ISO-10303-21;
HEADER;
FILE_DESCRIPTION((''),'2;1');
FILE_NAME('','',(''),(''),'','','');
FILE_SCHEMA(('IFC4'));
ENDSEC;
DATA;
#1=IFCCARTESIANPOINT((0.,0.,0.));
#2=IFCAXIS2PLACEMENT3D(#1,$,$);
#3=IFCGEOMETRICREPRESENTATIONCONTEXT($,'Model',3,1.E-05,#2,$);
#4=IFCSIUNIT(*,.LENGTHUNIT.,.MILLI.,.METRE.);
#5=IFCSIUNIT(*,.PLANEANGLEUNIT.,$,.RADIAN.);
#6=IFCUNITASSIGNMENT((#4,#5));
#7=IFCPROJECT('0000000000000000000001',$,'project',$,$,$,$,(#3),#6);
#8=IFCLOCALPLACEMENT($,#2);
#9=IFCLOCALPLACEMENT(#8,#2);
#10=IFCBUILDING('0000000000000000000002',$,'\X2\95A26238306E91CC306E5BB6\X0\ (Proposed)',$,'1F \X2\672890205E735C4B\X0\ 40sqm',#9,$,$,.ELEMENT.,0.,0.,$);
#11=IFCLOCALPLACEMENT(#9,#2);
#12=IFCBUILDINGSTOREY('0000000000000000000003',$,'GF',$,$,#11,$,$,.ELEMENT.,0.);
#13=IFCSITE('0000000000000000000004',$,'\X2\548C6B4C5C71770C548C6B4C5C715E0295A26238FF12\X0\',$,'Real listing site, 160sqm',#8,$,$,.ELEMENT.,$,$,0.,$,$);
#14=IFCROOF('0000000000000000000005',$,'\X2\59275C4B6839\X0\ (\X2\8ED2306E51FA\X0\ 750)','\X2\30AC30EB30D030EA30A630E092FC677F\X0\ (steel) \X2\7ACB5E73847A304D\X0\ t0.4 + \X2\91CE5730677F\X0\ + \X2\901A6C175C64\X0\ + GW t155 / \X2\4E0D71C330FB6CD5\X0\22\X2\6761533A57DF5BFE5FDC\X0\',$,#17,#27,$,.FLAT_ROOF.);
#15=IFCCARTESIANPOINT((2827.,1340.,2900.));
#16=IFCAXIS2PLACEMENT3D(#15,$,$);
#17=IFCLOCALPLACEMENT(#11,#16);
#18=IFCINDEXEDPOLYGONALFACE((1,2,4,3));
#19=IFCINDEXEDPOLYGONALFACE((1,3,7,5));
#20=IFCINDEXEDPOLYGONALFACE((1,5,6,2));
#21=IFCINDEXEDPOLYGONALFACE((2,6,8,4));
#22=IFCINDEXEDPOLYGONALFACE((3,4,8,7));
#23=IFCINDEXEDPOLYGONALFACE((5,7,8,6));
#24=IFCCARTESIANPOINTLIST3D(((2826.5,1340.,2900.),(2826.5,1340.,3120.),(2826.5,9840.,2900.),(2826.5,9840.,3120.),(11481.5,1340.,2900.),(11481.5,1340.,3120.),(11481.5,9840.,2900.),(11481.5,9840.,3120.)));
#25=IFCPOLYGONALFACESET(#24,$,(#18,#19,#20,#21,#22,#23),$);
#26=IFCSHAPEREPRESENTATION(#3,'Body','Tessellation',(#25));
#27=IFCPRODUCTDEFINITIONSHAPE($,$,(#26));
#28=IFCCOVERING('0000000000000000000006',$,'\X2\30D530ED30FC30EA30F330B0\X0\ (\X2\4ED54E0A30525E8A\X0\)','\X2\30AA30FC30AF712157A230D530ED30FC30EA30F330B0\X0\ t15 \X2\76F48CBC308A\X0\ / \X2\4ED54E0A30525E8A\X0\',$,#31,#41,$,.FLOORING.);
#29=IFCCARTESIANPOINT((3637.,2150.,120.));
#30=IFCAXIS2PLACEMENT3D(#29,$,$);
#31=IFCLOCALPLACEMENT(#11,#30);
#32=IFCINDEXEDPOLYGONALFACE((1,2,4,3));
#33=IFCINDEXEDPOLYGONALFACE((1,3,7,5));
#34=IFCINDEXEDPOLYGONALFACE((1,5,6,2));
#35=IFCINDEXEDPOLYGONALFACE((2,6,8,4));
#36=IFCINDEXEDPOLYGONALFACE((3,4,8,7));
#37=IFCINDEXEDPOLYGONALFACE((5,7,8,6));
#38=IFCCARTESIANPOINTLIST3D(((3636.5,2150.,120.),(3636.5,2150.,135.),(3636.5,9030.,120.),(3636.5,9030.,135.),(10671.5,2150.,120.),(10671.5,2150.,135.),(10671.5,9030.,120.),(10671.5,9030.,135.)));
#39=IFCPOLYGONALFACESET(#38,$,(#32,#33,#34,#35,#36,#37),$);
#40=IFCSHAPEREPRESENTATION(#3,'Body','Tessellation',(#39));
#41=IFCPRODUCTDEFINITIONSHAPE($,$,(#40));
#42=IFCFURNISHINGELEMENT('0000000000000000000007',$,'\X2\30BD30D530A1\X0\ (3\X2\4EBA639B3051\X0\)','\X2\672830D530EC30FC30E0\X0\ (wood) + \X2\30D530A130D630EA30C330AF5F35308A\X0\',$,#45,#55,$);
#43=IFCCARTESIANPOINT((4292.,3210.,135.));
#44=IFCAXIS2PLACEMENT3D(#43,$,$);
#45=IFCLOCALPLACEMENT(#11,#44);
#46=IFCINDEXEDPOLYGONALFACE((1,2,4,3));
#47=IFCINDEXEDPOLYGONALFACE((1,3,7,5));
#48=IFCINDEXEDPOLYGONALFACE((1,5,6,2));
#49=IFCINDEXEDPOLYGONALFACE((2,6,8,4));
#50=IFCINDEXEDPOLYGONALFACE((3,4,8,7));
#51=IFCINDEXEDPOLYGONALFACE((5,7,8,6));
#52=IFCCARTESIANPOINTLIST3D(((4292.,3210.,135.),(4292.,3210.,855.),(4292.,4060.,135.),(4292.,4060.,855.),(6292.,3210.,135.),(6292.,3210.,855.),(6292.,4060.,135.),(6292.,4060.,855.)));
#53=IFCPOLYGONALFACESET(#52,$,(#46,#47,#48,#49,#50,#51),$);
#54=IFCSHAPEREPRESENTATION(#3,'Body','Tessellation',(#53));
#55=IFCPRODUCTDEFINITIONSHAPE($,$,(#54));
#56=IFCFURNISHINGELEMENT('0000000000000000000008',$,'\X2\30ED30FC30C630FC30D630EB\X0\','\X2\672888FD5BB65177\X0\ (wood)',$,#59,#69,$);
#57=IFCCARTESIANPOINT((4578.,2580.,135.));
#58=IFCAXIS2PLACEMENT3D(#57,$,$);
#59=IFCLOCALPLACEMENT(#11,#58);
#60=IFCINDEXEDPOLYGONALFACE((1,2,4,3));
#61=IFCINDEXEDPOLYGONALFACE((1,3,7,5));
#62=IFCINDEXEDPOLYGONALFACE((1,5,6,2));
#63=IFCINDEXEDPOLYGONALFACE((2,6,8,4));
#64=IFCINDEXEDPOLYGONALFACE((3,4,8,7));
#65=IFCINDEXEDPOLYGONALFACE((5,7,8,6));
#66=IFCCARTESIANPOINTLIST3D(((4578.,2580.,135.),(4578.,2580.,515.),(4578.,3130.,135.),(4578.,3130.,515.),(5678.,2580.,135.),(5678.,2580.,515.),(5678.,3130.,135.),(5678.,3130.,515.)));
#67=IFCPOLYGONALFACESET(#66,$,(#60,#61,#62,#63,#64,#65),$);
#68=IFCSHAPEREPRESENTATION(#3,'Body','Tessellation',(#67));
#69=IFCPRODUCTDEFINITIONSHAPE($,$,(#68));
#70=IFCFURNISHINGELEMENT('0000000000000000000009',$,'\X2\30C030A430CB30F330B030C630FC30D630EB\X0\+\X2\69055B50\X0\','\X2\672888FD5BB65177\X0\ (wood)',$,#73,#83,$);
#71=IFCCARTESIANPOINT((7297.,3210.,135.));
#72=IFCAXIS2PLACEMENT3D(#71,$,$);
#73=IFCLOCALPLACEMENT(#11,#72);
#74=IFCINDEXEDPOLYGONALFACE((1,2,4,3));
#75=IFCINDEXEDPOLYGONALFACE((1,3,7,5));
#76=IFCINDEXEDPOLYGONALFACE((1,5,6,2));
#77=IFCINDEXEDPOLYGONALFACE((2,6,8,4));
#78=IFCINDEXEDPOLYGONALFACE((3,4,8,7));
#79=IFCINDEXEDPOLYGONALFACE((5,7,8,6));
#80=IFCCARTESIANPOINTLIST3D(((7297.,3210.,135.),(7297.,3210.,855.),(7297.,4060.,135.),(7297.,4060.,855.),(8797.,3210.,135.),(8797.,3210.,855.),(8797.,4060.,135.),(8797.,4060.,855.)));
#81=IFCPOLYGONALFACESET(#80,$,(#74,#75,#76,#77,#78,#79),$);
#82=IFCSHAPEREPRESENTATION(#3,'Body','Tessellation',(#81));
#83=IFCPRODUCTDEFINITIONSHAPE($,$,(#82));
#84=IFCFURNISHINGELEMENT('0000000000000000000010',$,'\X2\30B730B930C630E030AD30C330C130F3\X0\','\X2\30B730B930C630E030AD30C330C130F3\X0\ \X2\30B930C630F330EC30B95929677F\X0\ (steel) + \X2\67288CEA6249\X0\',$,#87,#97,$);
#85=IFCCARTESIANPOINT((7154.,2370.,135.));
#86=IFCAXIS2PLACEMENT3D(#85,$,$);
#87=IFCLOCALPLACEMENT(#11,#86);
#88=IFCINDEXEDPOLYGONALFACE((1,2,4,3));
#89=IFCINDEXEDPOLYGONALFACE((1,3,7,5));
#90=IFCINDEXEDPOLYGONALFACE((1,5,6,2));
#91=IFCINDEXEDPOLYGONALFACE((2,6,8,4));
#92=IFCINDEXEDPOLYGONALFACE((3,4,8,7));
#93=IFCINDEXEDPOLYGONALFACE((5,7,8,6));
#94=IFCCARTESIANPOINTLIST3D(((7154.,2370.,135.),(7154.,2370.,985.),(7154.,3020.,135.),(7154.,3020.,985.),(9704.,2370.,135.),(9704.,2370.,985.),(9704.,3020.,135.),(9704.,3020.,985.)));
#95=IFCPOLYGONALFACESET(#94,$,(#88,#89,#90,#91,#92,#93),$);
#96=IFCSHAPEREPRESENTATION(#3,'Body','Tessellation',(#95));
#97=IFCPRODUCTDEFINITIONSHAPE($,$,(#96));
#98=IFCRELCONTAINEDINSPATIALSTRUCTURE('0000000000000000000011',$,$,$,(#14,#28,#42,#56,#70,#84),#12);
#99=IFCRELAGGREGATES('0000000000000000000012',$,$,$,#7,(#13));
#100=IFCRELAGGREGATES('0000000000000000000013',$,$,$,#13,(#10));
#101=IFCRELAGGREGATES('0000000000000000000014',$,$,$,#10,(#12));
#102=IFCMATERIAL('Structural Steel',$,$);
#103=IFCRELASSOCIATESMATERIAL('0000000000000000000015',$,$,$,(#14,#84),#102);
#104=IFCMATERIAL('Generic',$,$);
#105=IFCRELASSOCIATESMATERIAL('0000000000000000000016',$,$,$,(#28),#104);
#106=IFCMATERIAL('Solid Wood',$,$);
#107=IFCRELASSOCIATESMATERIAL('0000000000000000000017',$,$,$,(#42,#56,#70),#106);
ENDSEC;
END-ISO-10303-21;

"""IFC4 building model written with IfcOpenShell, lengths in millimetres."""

from ifc_helpers import new_model, si_unit, frame, frame_2d, origin, place, context, project, spatial, rectangle, extrude, material, element, save


model = new_model("IFC4")

# Units and contexts
model_context = context("Model", 3, precision=1e-05, world=origin())
ifc_project = project(units=[si_unit("LENGTHUNIT", "METRE", prefix="MILLI"), si_unit("PLANEANGLEUNIT", "RADIAN")], contexts=[model_context])

# Site, building, storey
site_placement = place(None, origin())
site = spatial("IfcSite", under=ifc_project, at=site_placement, Name="和歌山県和歌山市関戸２", ObjectType="Real listing site, 160sqm", CompositionType="ELEMENT", RefElevation=0.0)
building_placement = place(site_placement, origin())
building = spatial("IfcBuilding", under=site, at=building_placement, Name="関戸の里の家 (Proposed)", ObjectType="1F 木造平屋 40sqm", CompositionType="ELEMENT", ElevationOfRefHeight=0.0, ElevationOfTerrain=0.0)
storey_placement = place(building_placement, origin())
storey = spatial("IfcBuildingStorey", under=building, at=storey_placement, Name="GF", CompositionType="ELEMENT", Elevation=0.0)

# Shared definitions
ifc_material_1 = material(Name="Solid Wood")

# Roof
ifc_material_2 = material(Name="Structural Steel")
roof_placement = place(storey_placement, frame((2827.0, 1340.0, 2900.0)))
element("IfcRoof", 1, at=roof_placement, inside=storey, material=ifc_material_2, Name="大屋根 (軒の出 750)", Description="ガルバリウム鋼板 (steel) 立平葺き t0.4 + 野地板 + 通気層 + GW t155 / 不燃・法22条区域対応", PredefinedType="FLAT_ROOF", context=model_context, shape_type="SweptSolid", body=[
    extrude(rectangle(XDim=8655.0, YDim=8500.0, at=frame_2d((4327.0, 4250.0))), frame((2827.0, 1340.0, 2900.0)), (0.0, 0.0, 1.0), 220.0),
])

# Covering
ifc_material_3 = material(Name="Generic")
covering_placement = place(storey_placement, frame((3637.0, 2150.0, 120.0)))
element("IfcCovering", 2, at=covering_placement, inside=storey, material=ifc_material_3, Name="フローリング (仕上げ床)", Description="オーク無垢フローリング t15 直貼り / 仕上げ床", PredefinedType="FLOORING", context=model_context, shape_type="SweptSolid", body=[
    extrude(rectangle(XDim=7035.0, YDim=6880.0, at=frame_2d((3517.0, 3440.0))), frame((3637.0, 2150.0, 120.0)), (0.0, 0.0, 1.0), 15.0),
])

# Furnishing elements
furnishing_1_placement = place(storey_placement, frame((4292.0, 3210.0, 135.0)))
element("IfcFurnishingElement", 3, at=furnishing_1_placement, inside=storey, material=ifc_material_1, Name="ソファ (3人掛け)", Description="木フレーム (wood) + ファブリック張り", context=model_context, shape_type="SweptSolid", body=[
    extrude(rectangle(XDim=2000.0, YDim=850.0, at=frame_2d((1000.0, 425.0))), frame((4292.0, 3210.0, 135.0)), (0.0, 0.0, 1.0), 720.0),
])
furnishing_2_placement = place(storey_placement, frame((4578.0, 2580.0, 135.0)))
element("IfcFurnishingElement", 4, at=furnishing_2_placement, inside=storey, material=ifc_material_1, Name="ローテーブル", Description="木製家具 (wood)", context=model_context, shape_type="SweptSolid", body=[
    extrude(rectangle(XDim=1100.0, YDim=550.0, at=frame_2d((550.0, 275.0))), frame((4578.0, 2580.0, 135.0)), (0.0, 0.0, 1.0), 380.0),
])
furnishing_3_placement = place(storey_placement, frame((7297.0, 3210.0, 135.0)))
element("IfcFurnishingElement", 5, at=furnishing_3_placement, inside=storey, material=ifc_material_1, Name="ダイニングテーブル+椅子", Description="木製家具 (wood)", context=model_context, shape_type="SweptSolid", body=[
    extrude(rectangle(XDim=1500.0, YDim=850.0, at=frame_2d((750.0, 425.0))), frame((7297.0, 3210.0, 135.0)), (0.0, 0.0, 1.0), 720.0),
])
furnishing_4_placement = place(storey_placement, frame((7154.0, 2370.0, 135.0)))
element("IfcFurnishingElement", 6, at=furnishing_4_placement, inside=storey, material=ifc_material_2, Name="システムキッチン", Description="システムキッチン ステンレス天板 (steel) + 木質扉", context=model_context, shape_type="SweptSolid", body=[
    extrude(rectangle(XDim=2550.0, YDim=650.0, at=frame_2d((1275.0, 325.0))), frame((7154.0, 2370.0, 135.0)), (0.0, 0.0, 1.0), 850.0),
])

save(model, "model.ifc")
